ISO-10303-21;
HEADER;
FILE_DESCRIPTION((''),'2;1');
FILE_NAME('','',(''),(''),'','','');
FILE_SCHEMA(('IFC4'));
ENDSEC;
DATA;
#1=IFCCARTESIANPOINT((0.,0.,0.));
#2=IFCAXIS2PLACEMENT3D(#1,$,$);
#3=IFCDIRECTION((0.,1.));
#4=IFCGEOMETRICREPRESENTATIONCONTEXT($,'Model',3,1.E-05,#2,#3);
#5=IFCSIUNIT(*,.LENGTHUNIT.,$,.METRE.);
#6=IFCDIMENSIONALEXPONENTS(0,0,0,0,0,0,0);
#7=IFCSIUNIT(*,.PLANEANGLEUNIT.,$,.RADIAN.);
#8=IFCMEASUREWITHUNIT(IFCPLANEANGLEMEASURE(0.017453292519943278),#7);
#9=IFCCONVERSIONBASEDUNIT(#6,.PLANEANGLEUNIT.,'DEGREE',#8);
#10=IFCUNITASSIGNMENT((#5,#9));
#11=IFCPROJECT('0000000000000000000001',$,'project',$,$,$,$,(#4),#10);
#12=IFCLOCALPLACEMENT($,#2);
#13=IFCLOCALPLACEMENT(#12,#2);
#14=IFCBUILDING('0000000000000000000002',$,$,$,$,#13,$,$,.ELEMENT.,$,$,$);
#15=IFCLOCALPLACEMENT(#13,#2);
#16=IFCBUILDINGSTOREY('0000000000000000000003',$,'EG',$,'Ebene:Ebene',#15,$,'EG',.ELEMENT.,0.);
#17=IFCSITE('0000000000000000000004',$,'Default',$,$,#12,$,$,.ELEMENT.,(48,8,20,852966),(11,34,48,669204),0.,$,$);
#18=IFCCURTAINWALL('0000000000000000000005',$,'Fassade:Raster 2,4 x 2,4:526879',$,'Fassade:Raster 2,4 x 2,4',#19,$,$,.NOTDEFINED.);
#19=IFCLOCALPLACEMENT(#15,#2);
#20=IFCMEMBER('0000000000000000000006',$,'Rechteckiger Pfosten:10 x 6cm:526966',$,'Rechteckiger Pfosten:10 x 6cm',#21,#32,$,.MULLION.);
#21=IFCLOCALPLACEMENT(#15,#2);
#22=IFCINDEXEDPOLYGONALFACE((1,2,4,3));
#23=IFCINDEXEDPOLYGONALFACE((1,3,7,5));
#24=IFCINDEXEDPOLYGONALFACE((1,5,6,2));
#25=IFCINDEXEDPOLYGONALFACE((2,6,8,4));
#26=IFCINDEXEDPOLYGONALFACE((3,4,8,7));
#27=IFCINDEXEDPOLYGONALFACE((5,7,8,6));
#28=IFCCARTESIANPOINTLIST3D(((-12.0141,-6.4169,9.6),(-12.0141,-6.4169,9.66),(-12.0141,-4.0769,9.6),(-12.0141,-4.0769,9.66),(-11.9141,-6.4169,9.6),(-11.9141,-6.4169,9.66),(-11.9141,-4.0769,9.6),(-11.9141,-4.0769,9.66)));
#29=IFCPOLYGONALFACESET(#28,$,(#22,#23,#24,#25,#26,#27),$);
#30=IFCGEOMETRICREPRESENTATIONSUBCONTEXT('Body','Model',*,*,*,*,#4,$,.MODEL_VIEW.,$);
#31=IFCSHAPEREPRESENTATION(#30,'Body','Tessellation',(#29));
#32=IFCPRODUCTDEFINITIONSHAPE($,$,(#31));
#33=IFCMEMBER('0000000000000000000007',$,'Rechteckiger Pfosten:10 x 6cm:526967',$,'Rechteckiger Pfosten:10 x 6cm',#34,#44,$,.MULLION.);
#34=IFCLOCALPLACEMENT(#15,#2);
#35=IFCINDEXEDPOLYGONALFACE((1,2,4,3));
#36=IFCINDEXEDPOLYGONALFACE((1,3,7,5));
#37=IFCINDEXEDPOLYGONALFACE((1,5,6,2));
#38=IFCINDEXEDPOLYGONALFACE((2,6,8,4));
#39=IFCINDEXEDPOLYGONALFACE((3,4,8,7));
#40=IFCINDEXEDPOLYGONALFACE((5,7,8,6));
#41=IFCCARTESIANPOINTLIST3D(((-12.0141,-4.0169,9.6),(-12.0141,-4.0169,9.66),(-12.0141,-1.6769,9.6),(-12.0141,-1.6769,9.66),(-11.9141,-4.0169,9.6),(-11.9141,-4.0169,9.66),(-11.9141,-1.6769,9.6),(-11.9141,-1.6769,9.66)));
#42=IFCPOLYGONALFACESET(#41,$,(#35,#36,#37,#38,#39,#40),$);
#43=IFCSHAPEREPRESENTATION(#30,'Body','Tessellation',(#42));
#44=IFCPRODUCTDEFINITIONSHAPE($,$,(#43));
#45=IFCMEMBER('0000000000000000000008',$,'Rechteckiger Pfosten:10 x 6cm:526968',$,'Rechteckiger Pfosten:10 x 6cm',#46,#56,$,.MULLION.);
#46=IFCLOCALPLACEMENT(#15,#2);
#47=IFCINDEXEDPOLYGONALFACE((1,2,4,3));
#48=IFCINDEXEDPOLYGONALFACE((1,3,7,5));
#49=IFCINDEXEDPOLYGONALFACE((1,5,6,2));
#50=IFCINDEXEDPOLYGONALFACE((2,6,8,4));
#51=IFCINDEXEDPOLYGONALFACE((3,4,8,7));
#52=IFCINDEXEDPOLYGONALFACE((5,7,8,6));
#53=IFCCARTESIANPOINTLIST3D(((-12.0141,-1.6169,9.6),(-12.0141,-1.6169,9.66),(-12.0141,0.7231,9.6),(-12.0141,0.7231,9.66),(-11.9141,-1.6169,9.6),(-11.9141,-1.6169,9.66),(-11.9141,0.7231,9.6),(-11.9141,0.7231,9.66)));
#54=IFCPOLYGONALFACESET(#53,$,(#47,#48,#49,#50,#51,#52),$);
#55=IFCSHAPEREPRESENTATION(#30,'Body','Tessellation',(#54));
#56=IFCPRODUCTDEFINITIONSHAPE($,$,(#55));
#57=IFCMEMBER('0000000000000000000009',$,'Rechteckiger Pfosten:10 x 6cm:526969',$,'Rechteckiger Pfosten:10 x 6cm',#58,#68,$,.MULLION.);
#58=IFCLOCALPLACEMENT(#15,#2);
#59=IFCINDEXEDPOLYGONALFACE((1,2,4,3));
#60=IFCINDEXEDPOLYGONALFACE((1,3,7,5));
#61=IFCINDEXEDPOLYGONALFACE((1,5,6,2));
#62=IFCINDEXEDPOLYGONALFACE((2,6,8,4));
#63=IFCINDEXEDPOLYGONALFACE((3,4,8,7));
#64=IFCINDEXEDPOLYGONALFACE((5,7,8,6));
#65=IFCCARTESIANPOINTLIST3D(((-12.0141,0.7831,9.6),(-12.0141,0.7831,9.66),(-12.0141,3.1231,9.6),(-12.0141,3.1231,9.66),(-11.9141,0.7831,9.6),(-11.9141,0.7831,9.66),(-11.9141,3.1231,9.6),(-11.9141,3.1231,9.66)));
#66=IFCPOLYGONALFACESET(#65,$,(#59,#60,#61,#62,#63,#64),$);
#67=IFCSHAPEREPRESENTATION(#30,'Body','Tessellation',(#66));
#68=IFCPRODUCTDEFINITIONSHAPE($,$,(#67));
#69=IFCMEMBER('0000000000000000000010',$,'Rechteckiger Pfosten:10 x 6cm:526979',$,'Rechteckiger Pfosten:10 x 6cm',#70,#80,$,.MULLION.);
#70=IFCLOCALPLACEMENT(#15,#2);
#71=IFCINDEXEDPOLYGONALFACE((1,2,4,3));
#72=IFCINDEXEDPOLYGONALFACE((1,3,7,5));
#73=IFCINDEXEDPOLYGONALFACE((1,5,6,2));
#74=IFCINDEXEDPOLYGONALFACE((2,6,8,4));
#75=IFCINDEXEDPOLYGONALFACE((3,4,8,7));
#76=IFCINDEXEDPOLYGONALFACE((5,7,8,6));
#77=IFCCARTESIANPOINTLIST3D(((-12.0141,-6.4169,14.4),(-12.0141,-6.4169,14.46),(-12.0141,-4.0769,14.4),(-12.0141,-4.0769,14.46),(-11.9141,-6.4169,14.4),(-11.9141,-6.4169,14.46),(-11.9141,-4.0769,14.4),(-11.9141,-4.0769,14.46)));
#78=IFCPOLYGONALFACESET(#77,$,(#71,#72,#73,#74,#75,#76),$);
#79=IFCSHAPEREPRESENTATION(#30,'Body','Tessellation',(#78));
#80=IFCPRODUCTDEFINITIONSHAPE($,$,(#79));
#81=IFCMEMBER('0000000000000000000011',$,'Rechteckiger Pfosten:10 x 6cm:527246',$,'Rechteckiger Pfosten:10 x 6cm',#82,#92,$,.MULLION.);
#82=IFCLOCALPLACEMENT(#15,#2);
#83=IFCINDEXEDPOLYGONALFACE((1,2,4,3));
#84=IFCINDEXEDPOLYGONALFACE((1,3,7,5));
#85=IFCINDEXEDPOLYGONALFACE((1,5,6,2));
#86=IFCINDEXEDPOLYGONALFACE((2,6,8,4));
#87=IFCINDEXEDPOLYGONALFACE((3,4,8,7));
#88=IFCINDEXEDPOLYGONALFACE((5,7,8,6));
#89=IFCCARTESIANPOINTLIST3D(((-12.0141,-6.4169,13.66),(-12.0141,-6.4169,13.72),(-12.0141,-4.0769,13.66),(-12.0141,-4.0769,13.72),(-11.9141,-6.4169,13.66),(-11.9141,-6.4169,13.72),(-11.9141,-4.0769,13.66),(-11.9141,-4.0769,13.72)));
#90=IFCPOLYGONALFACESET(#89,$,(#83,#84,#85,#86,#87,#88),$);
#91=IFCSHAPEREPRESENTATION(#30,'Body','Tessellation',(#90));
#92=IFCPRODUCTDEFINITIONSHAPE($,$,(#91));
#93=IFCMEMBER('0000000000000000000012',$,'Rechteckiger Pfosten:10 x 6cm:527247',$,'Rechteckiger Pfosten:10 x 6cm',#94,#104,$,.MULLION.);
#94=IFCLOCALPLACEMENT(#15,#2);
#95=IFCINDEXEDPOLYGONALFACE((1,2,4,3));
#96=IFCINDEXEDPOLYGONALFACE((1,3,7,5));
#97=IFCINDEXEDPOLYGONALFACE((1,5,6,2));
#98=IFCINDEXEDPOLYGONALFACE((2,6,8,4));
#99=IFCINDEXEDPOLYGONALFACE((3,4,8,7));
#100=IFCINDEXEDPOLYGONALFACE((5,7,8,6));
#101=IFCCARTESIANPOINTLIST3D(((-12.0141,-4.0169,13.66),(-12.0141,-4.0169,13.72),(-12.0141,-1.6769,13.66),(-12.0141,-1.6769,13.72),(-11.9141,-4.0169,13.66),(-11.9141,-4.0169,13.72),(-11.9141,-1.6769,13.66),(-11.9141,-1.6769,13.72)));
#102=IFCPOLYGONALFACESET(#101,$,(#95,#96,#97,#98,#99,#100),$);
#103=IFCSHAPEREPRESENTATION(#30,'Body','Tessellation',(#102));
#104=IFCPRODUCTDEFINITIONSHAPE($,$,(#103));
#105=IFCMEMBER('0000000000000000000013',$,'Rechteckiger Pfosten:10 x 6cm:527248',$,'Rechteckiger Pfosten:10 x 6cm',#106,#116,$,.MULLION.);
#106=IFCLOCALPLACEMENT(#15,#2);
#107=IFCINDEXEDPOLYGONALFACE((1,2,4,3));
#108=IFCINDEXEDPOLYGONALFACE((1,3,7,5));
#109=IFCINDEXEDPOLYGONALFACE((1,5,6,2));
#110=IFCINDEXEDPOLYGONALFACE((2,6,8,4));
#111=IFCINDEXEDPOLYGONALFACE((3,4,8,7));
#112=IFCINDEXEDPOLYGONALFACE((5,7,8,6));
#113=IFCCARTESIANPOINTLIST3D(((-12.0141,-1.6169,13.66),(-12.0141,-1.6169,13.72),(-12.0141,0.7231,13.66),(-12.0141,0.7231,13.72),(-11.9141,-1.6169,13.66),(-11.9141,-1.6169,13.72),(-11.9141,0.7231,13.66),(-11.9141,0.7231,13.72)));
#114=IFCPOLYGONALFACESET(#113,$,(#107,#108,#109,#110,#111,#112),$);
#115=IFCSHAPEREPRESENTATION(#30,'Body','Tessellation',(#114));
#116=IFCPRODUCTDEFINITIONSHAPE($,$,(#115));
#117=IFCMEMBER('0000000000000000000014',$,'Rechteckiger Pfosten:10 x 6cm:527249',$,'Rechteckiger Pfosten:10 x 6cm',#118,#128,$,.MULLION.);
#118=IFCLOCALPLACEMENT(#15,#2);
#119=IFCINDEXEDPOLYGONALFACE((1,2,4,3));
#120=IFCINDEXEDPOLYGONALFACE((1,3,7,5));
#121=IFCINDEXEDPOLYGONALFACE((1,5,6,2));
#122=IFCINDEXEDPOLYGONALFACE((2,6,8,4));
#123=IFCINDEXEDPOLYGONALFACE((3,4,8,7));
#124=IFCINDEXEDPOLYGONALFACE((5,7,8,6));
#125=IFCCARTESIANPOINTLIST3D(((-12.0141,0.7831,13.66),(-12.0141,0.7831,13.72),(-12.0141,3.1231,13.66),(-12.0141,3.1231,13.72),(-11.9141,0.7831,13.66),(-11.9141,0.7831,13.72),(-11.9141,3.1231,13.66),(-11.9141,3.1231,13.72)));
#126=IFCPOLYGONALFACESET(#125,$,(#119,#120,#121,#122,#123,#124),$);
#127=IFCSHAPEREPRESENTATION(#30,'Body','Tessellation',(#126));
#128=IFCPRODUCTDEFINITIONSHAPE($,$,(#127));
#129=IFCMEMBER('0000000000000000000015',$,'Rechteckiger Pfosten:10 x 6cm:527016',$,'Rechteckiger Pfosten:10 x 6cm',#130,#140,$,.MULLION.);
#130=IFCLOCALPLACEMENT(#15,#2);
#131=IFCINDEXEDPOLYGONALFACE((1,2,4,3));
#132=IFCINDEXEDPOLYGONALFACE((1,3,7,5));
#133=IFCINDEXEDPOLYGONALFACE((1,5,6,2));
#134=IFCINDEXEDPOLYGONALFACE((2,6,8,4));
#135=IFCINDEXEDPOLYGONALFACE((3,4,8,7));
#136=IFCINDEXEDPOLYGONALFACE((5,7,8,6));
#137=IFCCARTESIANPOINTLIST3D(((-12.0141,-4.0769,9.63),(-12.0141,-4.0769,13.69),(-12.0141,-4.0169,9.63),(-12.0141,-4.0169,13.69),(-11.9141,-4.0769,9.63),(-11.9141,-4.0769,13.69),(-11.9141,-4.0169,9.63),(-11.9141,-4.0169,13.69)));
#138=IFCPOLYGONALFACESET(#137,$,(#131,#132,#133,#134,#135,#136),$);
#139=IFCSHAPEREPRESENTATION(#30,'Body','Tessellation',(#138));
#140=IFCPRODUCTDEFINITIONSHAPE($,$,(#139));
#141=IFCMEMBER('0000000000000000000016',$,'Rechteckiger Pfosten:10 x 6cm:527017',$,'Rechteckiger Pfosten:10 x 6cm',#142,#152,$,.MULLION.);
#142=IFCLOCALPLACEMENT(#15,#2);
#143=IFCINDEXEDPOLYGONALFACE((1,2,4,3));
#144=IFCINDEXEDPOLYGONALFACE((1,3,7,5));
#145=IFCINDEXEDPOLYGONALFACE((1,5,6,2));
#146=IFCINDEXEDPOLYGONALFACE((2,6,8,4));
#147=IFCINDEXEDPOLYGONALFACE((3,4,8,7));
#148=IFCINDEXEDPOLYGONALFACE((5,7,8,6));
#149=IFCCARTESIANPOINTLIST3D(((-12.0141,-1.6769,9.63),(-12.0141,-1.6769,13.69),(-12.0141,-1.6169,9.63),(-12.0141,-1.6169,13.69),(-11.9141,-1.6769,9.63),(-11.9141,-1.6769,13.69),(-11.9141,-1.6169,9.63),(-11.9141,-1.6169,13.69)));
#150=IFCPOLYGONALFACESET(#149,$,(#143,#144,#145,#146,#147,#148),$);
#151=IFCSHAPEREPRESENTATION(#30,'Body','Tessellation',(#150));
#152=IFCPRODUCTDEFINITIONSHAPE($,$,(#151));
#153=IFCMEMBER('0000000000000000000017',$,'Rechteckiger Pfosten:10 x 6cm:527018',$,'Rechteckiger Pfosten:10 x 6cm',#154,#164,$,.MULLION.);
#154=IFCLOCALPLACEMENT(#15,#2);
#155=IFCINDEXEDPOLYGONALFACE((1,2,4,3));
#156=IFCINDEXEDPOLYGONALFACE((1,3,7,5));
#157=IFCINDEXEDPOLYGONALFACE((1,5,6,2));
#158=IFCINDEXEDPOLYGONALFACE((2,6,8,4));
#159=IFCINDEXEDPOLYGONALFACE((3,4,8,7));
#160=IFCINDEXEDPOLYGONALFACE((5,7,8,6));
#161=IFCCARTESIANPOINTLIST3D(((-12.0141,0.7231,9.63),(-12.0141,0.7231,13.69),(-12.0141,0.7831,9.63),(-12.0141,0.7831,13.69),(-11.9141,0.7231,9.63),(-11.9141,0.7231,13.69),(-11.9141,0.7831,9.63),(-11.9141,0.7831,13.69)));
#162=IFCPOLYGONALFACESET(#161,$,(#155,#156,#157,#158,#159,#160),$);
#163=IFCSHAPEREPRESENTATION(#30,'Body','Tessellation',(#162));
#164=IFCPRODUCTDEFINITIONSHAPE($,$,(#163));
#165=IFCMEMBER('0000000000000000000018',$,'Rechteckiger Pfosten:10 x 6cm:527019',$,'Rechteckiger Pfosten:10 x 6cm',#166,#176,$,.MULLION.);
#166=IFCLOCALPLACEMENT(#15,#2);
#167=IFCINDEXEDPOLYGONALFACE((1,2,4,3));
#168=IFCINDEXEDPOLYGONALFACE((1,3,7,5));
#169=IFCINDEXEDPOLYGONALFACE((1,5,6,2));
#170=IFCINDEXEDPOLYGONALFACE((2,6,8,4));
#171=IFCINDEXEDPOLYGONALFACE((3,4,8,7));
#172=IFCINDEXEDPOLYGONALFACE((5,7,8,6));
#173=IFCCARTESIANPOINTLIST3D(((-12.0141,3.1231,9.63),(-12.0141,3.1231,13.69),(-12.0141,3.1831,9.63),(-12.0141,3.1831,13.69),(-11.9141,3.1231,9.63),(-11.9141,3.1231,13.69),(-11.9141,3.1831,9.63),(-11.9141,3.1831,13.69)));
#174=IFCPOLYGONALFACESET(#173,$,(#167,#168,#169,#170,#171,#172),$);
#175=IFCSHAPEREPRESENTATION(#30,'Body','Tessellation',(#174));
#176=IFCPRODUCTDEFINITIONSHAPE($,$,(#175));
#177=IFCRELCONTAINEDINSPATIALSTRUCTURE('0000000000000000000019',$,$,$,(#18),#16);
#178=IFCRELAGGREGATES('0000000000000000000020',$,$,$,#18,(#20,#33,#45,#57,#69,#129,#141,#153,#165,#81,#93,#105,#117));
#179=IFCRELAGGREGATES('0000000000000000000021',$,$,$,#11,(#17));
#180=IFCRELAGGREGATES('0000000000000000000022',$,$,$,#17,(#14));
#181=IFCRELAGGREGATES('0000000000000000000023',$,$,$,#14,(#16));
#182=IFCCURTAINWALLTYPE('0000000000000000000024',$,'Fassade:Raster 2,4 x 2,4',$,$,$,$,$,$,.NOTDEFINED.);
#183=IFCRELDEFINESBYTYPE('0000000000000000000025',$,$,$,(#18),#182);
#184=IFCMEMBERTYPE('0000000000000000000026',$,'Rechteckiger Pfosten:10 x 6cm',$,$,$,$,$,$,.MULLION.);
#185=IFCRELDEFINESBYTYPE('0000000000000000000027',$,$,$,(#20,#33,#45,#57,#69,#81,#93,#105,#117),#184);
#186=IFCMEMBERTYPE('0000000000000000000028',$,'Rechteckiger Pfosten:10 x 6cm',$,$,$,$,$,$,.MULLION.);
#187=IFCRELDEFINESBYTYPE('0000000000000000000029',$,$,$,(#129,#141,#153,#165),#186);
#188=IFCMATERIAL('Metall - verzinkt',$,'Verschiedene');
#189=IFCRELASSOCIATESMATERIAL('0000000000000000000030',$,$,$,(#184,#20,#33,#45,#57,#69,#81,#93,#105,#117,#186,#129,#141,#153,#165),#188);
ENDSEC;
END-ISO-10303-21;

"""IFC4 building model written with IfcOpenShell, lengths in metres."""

from ifc_helpers import new_model, entity, si_unit, converted_unit, direction, frame, origin, place, context, subcontext, project, spatial, indexed_curve, outline, extrude, source, transform, mapped, material, type_object, type_shapes, element, aggregate, save


model = new_model("IFC4")

# Units and contexts
model_context = context("Model", 3, precision=1e-05, world=origin(), true_north=direction((0.0, 1.0)))
body_context = subcontext(model_context, "Body", "Model", "MODEL_VIEW")
ifc_project = project(units=[si_unit("LENGTHUNIT", "METRE"), converted_unit("PLANEANGLEUNIT", "DEGREE", entity("IfcPlaneAngleMeasure", 0.017453292519943278), si_unit("PLANEANGLEUNIT", "RADIAN"), dimensions=[0, 0, 0, 0, 0, 0, 0])], contexts=[model_context])

# Site, building, storey
site_placement = place(None, origin())
site = spatial("IfcSite", under=ifc_project, at=site_placement, Name="Default", CompositionType="ELEMENT", RefLatitude=(48, 8, 20, 852966), RefLongitude=(11, 34, 48, 669204), RefElevation=0.0)
building_placement = place(site_placement, origin())
building = spatial("IfcBuilding", under=site, at=building_placement, CompositionType="ELEMENT")
storey_placement = place(building_placement, origin())
storey = spatial("IfcBuildingStorey", under=building, at=storey_placement, Name="EG", ObjectType="Ebene:Ebene", LongName="EG", CompositionType="ELEMENT", Elevation=0.0)

# Curtain wall, members
curtain_wall_type = type_object("IfcCurtainWallType", Name="Fassade:Raster 2,4 x 2,4", PredefinedType="NOTDEFINED")
curtain_wall_placement = place(storey_placement, origin())
curtain_wall = element("IfcCurtainWall", 1, at=curtain_wall_placement, inside=storey, type_object=curtain_wall_type, Name="Fassade:Raster 2,4 x 2,4:526879", ObjectType="Fassade:Raster 2,4 x 2,4", PredefinedType="NOTDEFINED")
ifc_material_1 = material(Name="Metall - verzinkt", Category="Verschiedene")
member_type_1 = type_object("IfcMemberType", Name="Rechteckiger Pfosten:10 x 6cm", PredefinedType="MULLION", material=ifc_material_1)
shared_shape_1 = source(origin(), body_context, "Body", "SweptSolid", [
    extrude(outline(indexed_curve([(-0.03, -0.05), (0.03, -0.05), (0.03, 0.05), (-0.03, 0.05), (-0.03, -0.05)], self_intersect=False)), frame((0.0, 0.0, -2.34), z_axis=(0.0, 0.0, 1.0), x_axis=(-1.0, 0.0, 0.0)), (0.0, 0.0, 1.0), 2.34),
])
type_shapes(member_type_1, [shared_shape_1])
member_1_placement = place(curtain_wall_placement, frame((-11.9641, -4.0769, 9.63), z_axis=(0.0, 1.0, 0.0), x_axis=(0.0, 0.0, 1.0)))
member_1 = element("IfcMember", 2, at=member_1_placement, type_object=member_type_1, material=ifc_material_1, Name="Rechteckiger Pfosten:10 x 6cm:526966", ObjectType="Rechteckiger Pfosten:10 x 6cm", PredefinedType="MULLION", context=body_context, shape_type="MappedRepresentation", body=[
    mapped(shared_shape_1, transform((0.0, 0.0, 0.0), scale=1.0)),
])
member_2_placement = place(curtain_wall_placement, frame((-11.9641, -1.6769, 9.63), z_axis=(0.0, 1.0, 0.0), x_axis=(0.0, 0.0, 1.0)))
member_2 = element("IfcMember", 3, at=member_2_placement, type_object=member_type_1, material=ifc_material_1, Name="Rechteckiger Pfosten:10 x 6cm:526967", ObjectType="Rechteckiger Pfosten:10 x 6cm", PredefinedType="MULLION", context=body_context, shape_type="MappedRepresentation", body=[
    mapped(shared_shape_1, transform((0.0, 0.0, 0.0), scale=1.0)),
])
member_3_placement = place(curtain_wall_placement, frame((-11.9641, 0.7231, 9.63), z_axis=(0.0, 1.0, 0.0), x_axis=(0.0, 0.0, 1.0)))
member_3 = element("IfcMember", 4, at=member_3_placement, type_object=member_type_1, material=ifc_material_1, Name="Rechteckiger Pfosten:10 x 6cm:526968", ObjectType="Rechteckiger Pfosten:10 x 6cm", PredefinedType="MULLION", context=body_context, shape_type="MappedRepresentation", body=[
    mapped(shared_shape_1, transform((0.0, 0.0, 0.0), scale=1.0)),
])
member_4_placement = place(curtain_wall_placement, frame((-11.9641, 3.1231, 9.63), z_axis=(0.0, 1.0, 0.0), x_axis=(0.0, 0.0, 1.0)))
member_4 = element("IfcMember", 5, at=member_4_placement, type_object=member_type_1, material=ifc_material_1, Name="Rechteckiger Pfosten:10 x 6cm:526969", ObjectType="Rechteckiger Pfosten:10 x 6cm", PredefinedType="MULLION", context=body_context, shape_type="MappedRepresentation", body=[
    mapped(shared_shape_1, transform((0.0, 0.0, 0.0), scale=1.0)),
])
member_5_placement = place(curtain_wall_placement, frame((-11.9641, -4.0769, 14.43), z_axis=(0.0, 1.0, 0.0), x_axis=(0.0, 0.0, 1.0)))
member_5 = element("IfcMember", 6, at=member_5_placement, type_object=member_type_1, material=ifc_material_1, Name="Rechteckiger Pfosten:10 x 6cm:526979", ObjectType="Rechteckiger Pfosten:10 x 6cm", PredefinedType="MULLION", context=body_context, shape_type="MappedRepresentation", body=[
    mapped(shared_shape_1, transform((0.0, 0.0, 0.0), scale=1.0)),
])
member_6_placement = place(curtain_wall_placement, frame((-11.9641, -4.0769, 13.69), z_axis=(0.0, 1.0, 0.0), x_axis=(0.0, 0.0, 1.0)))
member_6 = element("IfcMember", 7, at=member_6_placement, type_object=member_type_1, material=ifc_material_1, Name="Rechteckiger Pfosten:10 x 6cm:527246", ObjectType="Rechteckiger Pfosten:10 x 6cm", PredefinedType="MULLION", context=body_context, shape_type="MappedRepresentation", body=[
    mapped(shared_shape_1, transform((0.0, 0.0, 0.0), scale=1.0)),
])
member_7_placement = place(curtain_wall_placement, frame((-11.9641, -1.6769, 13.69), z_axis=(0.0, 1.0, 0.0), x_axis=(0.0, 0.0, 1.0)))
member_7 = element("IfcMember", 8, at=member_7_placement, type_object=member_type_1, material=ifc_material_1, Name="Rechteckiger Pfosten:10 x 6cm:527247", ObjectType="Rechteckiger Pfosten:10 x 6cm", PredefinedType="MULLION", context=body_context, shape_type="MappedRepresentation", body=[
    mapped(shared_shape_1, transform((0.0, 0.0, 0.0), scale=1.0)),
])
member_8_placement = place(curtain_wall_placement, frame((-11.9641, 0.7231, 13.69), z_axis=(0.0, 1.0, 0.0), x_axis=(0.0, 0.0, 1.0)))
member_8 = element("IfcMember", 9, at=member_8_placement, type_object=member_type_1, material=ifc_material_1, Name="Rechteckiger Pfosten:10 x 6cm:527248", ObjectType="Rechteckiger Pfosten:10 x 6cm", PredefinedType="MULLION", context=body_context, shape_type="MappedRepresentation", body=[
    mapped(shared_shape_1, transform((0.0, 0.0, 0.0), scale=1.0)),
])
member_9_placement = place(curtain_wall_placement, frame((-11.9641, 3.1231, 13.69), z_axis=(0.0, 1.0, 0.0), x_axis=(0.0, 0.0, 1.0)))
member_9 = element("IfcMember", 10, at=member_9_placement, type_object=member_type_1, material=ifc_material_1, Name="Rechteckiger Pfosten:10 x 6cm:527249", ObjectType="Rechteckiger Pfosten:10 x 6cm", PredefinedType="MULLION", context=body_context, shape_type="MappedRepresentation", body=[
    mapped(shared_shape_1, transform((0.0, 0.0, 0.0), scale=1.0)),
])
member_type_2 = type_object("IfcMemberType", Name="Rechteckiger Pfosten:10 x 6cm", PredefinedType="MULLION", material=ifc_material_1)
shared_shape_2 = source(origin(), body_context, "Body", "SweptSolid", [
    extrude(outline(indexed_curve([(-0.03, -0.05), (0.03, -0.05), (0.03, 0.05), (-0.03, 0.05), (-0.03, -0.05)], self_intersect=False)), frame((0.0, 0.0, -4.06), z_axis=(0.0, 0.0, 1.0), x_axis=(-1.0, 0.0, 0.0)), (0.0, 0.0, 1.0), 4.06),
])
type_shapes(member_type_2, [shared_shape_2])
member_10_placement = place(curtain_wall_placement, frame((-11.9641, -4.0469, 9.63), z_axis=(0.0, 0.0, -1.0), x_axis=(0.0, 1.0, 0.0)))
member_10 = element("IfcMember", 11, at=member_10_placement, type_object=member_type_2, material=ifc_material_1, Name="Rechteckiger Pfosten:10 x 6cm:527016", ObjectType="Rechteckiger Pfosten:10 x 6cm", PredefinedType="MULLION", context=body_context, shape_type="MappedRepresentation", body=[
    mapped(shared_shape_2, transform((0.0, 0.0, 0.0), scale=1.0)),
])
member_11_placement = place(curtain_wall_placement, frame((-11.9641, -1.6469, 9.63), z_axis=(0.0, 0.0, -1.0), x_axis=(0.0, 1.0, 0.0)))
member_11 = element("IfcMember", 12, at=member_11_placement, type_object=member_type_2, material=ifc_material_1, Name="Rechteckiger Pfosten:10 x 6cm:527017", ObjectType="Rechteckiger Pfosten:10 x 6cm", PredefinedType="MULLION", context=body_context, shape_type="MappedRepresentation", body=[
    mapped(shared_shape_2, transform((0.0, 0.0, 0.0), scale=1.0)),
])
member_12_placement = place(curtain_wall_placement, frame((-11.9641, 0.7531, 9.63), z_axis=(0.0, 0.0, -1.0), x_axis=(0.0, 1.0, 0.0)))
member_12 = element("IfcMember", 13, at=member_12_placement, type_object=member_type_2, material=ifc_material_1, Name="Rechteckiger Pfosten:10 x 6cm:527018", ObjectType="Rechteckiger Pfosten:10 x 6cm", PredefinedType="MULLION", context=body_context, shape_type="MappedRepresentation", body=[
    mapped(shared_shape_2, transform((0.0, 0.0, 0.0), scale=1.0)),
])
member_13_placement = place(curtain_wall_placement, frame((-11.9641, 3.1531, 9.63), z_axis=(0.0, 0.0, -1.0), x_axis=(0.0, 1.0, 0.0)))
member_13 = element("IfcMember", 14, at=member_13_placement, type_object=member_type_2, material=ifc_material_1, Name="Rechteckiger Pfosten:10 x 6cm:527019", ObjectType="Rechteckiger Pfosten:10 x 6cm", PredefinedType="MULLION", context=body_context, shape_type="MappedRepresentation", body=[
    mapped(shared_shape_2, transform((0.0, 0.0, 0.0), scale=1.0)),
])
aggregate(curtain_wall, [member_1, member_2, member_3, member_4, member_5, member_10, member_11, member_12, member_13, member_6, member_7, member_8, member_9])

save(model, "model.ifc")
